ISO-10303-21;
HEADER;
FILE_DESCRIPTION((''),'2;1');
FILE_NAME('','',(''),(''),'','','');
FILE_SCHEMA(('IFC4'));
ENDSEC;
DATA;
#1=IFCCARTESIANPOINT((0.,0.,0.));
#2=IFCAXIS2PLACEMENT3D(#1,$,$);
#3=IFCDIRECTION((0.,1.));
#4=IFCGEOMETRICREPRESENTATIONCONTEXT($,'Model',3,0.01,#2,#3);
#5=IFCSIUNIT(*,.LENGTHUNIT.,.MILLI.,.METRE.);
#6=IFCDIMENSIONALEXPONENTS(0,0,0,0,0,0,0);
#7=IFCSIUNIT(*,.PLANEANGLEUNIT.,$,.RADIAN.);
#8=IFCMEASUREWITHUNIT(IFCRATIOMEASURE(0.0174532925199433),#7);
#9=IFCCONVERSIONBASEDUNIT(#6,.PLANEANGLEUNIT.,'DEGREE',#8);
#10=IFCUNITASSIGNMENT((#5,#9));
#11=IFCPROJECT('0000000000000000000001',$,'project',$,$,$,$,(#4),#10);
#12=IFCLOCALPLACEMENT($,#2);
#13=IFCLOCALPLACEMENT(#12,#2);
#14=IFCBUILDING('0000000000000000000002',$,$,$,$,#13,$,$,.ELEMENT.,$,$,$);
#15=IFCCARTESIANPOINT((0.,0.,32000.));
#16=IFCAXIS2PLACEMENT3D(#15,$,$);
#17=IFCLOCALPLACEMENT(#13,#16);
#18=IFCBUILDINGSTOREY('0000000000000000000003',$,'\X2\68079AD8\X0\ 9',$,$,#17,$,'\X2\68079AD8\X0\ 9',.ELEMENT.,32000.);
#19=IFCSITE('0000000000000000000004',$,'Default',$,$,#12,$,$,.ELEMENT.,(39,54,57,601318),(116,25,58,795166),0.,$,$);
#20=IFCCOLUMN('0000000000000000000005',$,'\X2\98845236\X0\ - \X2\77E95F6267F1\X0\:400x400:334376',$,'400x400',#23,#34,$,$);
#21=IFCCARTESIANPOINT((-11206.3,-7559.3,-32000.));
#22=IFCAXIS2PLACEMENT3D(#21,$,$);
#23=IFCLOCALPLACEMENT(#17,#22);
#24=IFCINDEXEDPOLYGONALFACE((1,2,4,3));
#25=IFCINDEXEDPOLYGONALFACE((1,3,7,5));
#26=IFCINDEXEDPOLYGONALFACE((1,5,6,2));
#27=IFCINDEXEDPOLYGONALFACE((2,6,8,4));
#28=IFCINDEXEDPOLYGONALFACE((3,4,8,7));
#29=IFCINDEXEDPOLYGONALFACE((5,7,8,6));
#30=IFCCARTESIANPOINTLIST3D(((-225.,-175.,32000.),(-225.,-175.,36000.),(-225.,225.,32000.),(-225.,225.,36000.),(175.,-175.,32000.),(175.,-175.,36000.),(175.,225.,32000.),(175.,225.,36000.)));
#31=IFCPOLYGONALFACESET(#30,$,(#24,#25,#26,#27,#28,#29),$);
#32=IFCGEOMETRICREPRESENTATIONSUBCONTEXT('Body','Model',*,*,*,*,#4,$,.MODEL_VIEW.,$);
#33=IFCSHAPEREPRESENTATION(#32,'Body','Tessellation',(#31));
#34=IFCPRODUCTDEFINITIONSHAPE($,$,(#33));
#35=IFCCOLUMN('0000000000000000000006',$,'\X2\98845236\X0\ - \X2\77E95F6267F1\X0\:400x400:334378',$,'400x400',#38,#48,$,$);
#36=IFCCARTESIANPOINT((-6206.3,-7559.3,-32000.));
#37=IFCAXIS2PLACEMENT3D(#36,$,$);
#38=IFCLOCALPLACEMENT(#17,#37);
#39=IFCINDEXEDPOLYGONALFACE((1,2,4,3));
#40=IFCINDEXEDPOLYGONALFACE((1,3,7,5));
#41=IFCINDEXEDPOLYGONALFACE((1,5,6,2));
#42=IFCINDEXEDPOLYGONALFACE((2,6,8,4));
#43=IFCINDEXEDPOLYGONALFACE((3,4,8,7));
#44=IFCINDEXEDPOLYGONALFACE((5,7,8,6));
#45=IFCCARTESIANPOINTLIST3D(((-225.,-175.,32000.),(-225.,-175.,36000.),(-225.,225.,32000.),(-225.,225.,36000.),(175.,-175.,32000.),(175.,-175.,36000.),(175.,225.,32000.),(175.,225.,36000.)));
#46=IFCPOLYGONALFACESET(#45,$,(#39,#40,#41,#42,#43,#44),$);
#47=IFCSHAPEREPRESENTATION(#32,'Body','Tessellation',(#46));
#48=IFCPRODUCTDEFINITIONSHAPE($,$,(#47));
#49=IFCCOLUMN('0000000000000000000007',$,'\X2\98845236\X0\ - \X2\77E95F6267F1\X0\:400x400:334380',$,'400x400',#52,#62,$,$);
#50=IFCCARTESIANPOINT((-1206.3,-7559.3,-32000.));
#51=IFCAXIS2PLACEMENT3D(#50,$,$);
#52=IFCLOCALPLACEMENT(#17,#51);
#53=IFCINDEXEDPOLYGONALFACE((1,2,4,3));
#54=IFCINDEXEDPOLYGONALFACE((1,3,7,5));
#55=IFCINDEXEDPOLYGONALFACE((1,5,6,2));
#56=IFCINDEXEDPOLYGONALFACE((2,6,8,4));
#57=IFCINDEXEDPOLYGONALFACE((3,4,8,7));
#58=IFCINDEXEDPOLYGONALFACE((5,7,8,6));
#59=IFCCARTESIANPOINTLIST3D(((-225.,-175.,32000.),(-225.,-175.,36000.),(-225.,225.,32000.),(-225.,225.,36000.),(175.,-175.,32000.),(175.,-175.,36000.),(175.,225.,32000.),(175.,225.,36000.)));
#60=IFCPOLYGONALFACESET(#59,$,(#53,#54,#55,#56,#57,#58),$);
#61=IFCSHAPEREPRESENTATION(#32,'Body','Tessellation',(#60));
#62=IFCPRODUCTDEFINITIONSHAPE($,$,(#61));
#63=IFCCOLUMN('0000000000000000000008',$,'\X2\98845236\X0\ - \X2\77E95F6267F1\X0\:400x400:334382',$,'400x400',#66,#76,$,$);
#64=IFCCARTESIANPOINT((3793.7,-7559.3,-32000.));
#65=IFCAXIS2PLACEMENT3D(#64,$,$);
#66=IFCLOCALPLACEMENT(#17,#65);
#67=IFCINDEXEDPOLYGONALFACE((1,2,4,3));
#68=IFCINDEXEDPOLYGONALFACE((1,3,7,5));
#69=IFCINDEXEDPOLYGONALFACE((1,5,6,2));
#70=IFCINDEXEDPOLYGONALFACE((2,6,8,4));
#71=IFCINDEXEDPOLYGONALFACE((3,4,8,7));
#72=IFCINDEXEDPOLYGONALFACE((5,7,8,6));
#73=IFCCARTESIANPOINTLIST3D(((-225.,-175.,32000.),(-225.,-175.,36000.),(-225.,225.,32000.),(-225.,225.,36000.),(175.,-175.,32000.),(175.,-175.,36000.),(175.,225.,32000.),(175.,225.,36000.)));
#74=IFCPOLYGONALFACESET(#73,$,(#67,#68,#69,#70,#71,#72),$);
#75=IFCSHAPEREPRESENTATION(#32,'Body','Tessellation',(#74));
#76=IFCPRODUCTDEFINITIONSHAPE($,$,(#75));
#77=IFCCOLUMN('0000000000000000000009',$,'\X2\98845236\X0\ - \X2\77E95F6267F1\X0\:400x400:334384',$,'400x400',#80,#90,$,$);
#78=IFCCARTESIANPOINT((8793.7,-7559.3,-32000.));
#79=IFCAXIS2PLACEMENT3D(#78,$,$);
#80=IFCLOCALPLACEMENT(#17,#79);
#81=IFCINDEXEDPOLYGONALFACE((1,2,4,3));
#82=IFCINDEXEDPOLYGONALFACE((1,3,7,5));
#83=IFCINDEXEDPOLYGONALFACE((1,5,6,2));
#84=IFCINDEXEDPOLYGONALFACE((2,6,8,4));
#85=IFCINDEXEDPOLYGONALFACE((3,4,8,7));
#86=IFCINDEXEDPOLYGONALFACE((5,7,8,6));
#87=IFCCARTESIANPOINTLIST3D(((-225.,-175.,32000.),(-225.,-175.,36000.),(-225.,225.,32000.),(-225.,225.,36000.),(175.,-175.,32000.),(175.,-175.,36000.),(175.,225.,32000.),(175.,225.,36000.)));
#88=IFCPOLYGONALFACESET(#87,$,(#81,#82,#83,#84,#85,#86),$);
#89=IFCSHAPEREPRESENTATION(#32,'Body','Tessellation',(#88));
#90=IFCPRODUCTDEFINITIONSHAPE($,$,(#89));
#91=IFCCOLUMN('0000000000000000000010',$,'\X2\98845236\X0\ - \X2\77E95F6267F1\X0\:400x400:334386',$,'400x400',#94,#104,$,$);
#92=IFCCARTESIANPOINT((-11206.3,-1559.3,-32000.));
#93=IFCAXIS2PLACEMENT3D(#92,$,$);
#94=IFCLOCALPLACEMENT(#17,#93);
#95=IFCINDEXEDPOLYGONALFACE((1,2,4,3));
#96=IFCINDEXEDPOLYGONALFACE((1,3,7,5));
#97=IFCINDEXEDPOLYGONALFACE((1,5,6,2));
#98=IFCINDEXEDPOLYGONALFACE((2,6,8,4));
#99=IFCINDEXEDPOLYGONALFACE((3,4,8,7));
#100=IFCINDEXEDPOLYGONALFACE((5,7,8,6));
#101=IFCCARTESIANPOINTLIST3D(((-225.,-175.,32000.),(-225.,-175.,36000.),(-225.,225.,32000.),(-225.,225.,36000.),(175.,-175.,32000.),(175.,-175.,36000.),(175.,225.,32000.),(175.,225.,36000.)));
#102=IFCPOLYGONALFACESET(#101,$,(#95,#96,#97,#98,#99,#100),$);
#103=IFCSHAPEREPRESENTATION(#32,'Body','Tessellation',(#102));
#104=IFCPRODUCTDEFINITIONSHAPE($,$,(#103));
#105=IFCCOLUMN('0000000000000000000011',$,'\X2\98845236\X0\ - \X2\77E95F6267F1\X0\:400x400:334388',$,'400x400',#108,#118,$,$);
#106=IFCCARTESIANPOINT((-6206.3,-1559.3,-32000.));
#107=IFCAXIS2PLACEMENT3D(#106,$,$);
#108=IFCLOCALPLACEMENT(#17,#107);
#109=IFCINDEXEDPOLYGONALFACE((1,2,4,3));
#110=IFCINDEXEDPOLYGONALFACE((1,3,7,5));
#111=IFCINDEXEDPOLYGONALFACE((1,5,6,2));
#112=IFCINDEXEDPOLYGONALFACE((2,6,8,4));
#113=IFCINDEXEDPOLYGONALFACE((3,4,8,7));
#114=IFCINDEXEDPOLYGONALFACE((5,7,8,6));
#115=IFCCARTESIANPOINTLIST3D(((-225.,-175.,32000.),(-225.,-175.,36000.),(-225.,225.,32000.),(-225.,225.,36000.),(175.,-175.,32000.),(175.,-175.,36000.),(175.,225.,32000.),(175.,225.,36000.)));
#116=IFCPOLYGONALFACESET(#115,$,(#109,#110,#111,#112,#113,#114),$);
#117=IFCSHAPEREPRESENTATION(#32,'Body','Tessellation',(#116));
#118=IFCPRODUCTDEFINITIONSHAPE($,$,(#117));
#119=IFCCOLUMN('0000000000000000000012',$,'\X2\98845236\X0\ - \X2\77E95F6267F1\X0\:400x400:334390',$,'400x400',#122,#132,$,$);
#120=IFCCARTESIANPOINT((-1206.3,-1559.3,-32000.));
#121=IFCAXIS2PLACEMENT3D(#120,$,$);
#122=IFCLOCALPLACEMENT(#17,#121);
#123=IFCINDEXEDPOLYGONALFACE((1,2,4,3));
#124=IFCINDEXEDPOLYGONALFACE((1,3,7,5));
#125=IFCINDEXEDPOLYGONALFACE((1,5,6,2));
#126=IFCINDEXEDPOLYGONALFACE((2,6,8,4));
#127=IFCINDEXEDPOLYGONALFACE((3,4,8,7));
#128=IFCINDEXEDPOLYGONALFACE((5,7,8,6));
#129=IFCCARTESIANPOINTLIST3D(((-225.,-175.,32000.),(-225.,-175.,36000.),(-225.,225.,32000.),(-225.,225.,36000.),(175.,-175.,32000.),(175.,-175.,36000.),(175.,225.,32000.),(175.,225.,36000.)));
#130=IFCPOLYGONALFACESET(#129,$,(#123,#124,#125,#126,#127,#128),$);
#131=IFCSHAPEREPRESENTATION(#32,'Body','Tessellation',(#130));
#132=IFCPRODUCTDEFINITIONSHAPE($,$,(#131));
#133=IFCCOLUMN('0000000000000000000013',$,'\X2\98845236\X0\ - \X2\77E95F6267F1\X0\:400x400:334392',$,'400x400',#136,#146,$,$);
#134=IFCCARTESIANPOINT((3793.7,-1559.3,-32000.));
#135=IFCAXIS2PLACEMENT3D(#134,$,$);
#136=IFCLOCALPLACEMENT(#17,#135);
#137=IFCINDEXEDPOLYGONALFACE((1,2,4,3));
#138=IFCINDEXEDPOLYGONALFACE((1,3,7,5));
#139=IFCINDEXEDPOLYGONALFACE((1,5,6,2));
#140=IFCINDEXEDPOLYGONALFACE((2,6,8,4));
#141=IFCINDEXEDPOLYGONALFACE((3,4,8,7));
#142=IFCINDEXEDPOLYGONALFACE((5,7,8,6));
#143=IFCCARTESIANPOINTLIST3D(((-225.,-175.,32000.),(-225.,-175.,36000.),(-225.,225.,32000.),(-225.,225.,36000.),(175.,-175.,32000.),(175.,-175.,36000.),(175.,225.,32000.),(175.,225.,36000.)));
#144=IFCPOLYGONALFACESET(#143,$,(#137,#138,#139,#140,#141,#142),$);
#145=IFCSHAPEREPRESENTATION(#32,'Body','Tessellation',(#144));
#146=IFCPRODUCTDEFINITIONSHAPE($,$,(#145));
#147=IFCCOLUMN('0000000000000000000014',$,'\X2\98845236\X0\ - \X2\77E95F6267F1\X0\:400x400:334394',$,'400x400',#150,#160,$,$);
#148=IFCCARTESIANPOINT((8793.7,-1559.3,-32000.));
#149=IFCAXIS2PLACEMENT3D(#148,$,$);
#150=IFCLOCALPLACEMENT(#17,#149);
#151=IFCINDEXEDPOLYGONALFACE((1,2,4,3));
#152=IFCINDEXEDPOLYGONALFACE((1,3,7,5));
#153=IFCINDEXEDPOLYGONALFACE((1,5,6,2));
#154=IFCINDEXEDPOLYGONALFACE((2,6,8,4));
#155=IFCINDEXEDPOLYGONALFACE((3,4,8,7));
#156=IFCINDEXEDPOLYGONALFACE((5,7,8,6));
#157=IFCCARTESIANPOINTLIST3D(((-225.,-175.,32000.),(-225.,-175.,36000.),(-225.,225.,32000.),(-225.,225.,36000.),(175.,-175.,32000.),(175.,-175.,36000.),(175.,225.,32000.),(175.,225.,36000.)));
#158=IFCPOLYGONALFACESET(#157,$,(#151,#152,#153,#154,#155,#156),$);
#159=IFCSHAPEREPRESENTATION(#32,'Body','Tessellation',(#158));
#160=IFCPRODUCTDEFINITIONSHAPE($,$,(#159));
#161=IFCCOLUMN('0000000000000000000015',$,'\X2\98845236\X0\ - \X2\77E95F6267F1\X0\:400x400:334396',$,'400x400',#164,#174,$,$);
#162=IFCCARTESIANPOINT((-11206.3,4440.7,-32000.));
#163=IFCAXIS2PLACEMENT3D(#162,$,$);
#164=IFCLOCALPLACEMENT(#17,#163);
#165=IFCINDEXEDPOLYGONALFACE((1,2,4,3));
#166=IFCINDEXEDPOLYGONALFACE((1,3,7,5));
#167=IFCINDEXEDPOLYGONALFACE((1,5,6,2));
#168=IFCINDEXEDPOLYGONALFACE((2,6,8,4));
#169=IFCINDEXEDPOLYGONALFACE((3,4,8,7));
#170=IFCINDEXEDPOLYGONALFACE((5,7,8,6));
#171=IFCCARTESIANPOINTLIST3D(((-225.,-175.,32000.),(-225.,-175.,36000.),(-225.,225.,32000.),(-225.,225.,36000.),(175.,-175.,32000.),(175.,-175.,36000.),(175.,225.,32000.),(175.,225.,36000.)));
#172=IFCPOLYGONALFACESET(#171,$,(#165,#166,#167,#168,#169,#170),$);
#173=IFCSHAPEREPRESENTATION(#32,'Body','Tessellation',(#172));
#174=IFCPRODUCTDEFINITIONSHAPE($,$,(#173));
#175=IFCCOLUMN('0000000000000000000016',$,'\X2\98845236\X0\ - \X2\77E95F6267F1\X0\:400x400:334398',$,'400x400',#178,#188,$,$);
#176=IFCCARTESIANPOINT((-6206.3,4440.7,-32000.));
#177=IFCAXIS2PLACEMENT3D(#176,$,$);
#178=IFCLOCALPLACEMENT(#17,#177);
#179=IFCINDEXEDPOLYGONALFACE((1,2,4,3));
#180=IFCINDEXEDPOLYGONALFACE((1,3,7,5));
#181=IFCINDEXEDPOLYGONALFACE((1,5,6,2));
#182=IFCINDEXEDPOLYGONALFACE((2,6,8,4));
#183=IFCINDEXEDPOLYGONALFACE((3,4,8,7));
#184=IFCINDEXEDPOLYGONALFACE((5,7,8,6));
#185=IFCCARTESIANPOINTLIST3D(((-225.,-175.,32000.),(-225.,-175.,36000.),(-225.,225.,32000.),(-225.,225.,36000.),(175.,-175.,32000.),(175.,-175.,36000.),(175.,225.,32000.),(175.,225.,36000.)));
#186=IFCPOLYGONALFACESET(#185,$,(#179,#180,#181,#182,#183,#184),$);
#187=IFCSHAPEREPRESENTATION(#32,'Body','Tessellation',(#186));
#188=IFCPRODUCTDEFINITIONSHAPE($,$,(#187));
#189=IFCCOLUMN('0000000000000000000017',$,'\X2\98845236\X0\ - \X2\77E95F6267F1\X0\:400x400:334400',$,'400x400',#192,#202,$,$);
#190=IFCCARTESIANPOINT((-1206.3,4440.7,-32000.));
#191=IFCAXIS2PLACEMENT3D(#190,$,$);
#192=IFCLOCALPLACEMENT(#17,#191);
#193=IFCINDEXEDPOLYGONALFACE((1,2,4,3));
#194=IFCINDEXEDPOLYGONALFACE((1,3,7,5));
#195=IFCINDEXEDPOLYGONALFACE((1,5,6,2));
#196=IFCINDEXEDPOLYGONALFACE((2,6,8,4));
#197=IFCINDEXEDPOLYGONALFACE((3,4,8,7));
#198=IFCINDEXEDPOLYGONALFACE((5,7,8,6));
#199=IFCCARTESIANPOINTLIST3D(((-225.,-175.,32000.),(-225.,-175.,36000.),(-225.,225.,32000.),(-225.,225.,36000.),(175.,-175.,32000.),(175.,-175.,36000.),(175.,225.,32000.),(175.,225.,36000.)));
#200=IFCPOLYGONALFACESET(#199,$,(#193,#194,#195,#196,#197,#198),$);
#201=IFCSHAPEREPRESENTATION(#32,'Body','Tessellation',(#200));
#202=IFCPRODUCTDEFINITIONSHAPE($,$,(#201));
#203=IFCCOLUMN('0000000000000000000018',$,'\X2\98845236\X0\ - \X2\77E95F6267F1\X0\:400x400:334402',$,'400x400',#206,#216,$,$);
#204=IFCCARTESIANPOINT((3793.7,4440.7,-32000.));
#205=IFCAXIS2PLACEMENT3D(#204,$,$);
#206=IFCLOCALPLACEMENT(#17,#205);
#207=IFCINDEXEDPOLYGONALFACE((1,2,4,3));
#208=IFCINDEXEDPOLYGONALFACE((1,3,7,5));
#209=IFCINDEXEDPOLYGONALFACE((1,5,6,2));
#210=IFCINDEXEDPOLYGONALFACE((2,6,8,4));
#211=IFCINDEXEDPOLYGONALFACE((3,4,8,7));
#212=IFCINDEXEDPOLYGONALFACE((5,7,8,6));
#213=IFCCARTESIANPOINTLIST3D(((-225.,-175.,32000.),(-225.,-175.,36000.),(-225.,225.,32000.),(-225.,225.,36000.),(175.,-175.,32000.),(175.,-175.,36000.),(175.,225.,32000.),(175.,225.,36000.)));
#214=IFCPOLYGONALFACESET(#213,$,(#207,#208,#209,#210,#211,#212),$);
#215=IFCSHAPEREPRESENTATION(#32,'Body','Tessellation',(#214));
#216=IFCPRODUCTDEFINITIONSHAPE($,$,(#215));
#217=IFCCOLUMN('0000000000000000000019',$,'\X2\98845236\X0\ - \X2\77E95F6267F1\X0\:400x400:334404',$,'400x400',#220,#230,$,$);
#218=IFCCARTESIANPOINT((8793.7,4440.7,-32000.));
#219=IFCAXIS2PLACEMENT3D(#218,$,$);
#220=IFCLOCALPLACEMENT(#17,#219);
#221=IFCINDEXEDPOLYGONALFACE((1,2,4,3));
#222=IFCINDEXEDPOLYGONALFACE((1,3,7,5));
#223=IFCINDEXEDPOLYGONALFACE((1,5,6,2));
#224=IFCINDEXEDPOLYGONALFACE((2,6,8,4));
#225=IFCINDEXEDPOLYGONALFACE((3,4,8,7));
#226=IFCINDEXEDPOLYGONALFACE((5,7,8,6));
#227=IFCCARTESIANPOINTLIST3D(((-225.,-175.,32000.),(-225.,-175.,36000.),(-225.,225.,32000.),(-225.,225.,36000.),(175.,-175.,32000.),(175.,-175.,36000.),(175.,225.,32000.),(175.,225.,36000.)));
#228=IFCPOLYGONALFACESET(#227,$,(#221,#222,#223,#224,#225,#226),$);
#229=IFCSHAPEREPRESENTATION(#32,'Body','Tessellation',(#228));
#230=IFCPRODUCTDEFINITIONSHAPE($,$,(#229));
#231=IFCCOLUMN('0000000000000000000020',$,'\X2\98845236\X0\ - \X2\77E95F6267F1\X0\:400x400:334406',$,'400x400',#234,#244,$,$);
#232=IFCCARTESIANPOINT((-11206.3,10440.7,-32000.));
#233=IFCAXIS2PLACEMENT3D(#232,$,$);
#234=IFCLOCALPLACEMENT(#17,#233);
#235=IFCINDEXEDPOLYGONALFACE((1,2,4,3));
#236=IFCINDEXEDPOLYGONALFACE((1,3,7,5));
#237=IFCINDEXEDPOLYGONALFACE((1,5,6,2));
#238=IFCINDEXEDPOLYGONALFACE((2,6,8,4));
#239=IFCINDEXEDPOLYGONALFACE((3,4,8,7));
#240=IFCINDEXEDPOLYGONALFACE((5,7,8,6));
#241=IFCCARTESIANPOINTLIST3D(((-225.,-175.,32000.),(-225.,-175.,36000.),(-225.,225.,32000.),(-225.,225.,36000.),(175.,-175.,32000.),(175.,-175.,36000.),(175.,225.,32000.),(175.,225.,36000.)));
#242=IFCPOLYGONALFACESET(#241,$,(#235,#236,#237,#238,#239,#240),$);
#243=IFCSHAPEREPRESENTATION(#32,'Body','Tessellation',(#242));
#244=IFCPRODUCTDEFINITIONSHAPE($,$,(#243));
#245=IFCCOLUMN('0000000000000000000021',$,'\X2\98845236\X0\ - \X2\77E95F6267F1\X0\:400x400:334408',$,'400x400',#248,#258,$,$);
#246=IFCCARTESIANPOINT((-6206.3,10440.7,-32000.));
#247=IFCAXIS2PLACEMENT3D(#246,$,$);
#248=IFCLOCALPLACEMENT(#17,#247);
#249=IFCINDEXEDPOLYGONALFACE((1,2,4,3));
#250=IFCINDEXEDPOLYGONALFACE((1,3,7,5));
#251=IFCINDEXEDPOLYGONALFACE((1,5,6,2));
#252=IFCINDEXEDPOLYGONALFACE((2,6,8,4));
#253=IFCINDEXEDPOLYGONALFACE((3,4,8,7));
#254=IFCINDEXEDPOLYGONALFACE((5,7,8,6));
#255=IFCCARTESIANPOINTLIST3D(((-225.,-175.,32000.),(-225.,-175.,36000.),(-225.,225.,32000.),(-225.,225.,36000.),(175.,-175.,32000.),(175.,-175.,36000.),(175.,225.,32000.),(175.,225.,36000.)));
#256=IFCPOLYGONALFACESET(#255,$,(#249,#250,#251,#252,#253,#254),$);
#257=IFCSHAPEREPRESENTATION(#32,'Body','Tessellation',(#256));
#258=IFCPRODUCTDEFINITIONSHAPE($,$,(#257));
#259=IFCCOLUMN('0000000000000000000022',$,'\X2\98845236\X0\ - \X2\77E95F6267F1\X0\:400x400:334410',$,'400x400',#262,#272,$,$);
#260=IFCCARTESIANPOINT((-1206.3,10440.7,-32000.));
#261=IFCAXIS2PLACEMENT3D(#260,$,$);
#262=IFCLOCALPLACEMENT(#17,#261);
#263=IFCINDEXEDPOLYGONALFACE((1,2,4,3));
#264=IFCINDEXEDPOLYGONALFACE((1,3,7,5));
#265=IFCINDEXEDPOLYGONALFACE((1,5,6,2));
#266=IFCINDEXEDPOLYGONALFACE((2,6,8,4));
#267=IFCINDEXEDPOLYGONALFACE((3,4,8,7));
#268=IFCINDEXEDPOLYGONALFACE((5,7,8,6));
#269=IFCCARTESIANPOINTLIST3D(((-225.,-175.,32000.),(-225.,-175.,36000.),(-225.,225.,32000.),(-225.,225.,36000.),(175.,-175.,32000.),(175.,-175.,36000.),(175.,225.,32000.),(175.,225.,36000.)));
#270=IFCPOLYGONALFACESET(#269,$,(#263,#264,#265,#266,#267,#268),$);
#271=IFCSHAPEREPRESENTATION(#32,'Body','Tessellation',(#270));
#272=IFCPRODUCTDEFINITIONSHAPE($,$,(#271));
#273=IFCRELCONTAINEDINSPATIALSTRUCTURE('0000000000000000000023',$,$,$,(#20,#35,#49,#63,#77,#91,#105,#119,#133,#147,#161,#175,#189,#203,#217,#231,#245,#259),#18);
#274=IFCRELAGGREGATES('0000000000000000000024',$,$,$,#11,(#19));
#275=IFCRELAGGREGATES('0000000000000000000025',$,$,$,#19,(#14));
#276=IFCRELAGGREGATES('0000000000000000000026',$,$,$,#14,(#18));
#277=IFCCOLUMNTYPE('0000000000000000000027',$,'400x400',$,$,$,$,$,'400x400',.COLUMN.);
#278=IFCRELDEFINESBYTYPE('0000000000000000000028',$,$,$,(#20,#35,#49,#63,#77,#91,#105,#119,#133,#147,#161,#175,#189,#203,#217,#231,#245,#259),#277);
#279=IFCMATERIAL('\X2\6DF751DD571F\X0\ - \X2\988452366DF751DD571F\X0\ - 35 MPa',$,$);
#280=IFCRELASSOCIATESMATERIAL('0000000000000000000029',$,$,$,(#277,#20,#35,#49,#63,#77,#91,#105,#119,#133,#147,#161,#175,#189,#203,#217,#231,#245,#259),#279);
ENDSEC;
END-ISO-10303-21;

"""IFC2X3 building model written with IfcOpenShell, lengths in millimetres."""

from ifc_helpers import new_model, entity, si_unit, converted_unit, direction, frame, frame_2d, origin, place, context, subcontext, project, spatial, rectangle, extrude, source, transform, mapped, material, type_object, type_shapes, element, save


model = new_model("IFC2X3")

# Units and contexts
model_context = context("Model", 3, precision=0.01, world=origin(), true_north=direction((0.0, 1.0)))
body_context = subcontext(model_context, "Body", "Model", "MODEL_VIEW")
ifc_project = project(units=[si_unit("LENGTHUNIT", "METRE", prefix="MILLI"), converted_unit("PLANEANGLEUNIT", "DEGREE", entity("IfcRatioMeasure", 0.0174532925199433), si_unit("PLANEANGLEUNIT", "RADIAN"), dimensions=[0, 0, 0, 0, 0, 0, 0])], contexts=[model_context])

# Site, building, storey
site_placement = place(None, origin())
site = spatial("IfcSite", under=ifc_project, at=site_placement, Name="Default", CompositionType="ELEMENT", RefLatitude=(39, 54, 57, 601318), RefLongitude=(116, 25, 58, 795166), RefElevation=0.0)
building_placement = place(site_placement, origin())
building = spatial("IfcBuilding", under=site, at=building_placement, CompositionType="ELEMENT")
storey_placement = place(building_placement, frame((0.0, 0.0, 32000.0)))
storey = spatial("IfcBuildingStorey", under=building, at=storey_placement, Name="标高 9", LongName="标高 9", CompositionType="ELEMENT", Elevation=32000.0)

# Columns
ifc_material = material(Name="混凝土 - 预制混凝土 - 35 MPa")
column_type = type_object("IfcColumnType", Name="400x400", ElementType="400x400", PredefinedType="COLUMN", material=ifc_material)
shared_shape = source(origin(), body_context, "Body", "SweptSolid", [
    extrude(rectangle(XDim=400.0, YDim=400.0, at=frame_2d((0.0, 0.0), x_axis=(1.0, 0.0))), frame((-25.0, 25.0, 32000.0)), (0.0, 0.0, 1.0), 4000.0),
])
type_shapes(column_type, [shared_shape])
for number, where, name in (
    (1, (-11206.3, -7559.3, -32000.0), "预制 - 矩形柱:400x400:334376"),
    (2, (-6206.3, -7559.3, -32000.0), "预制 - 矩形柱:400x400:334378"),
    (3, (-1206.3, -7559.3, -32000.0), "预制 - 矩形柱:400x400:334380"),
    (4, (3793.7, -7559.3, -32000.0), "预制 - 矩形柱:400x400:334382"),
    (5, (8793.7, -7559.3, -32000.0), "预制 - 矩形柱:400x400:334384"),
    (6, (-11206.3, -1559.3, -32000.0), "预制 - 矩形柱:400x400:334386"),
    (7, (-6206.3, -1559.3, -32000.0), "预制 - 矩形柱:400x400:334388"),
    (8, (-1206.3, -1559.3, -32000.0), "预制 - 矩形柱:400x400:334390"),
    (9, (3793.7, -1559.3, -32000.0), "预制 - 矩形柱:400x400:334392"),
    (10, (8793.7, -1559.3, -32000.0), "预制 - 矩形柱:400x400:334394"),
    (11, (-11206.3, 4440.7, -32000.0), "预制 - 矩形柱:400x400:334396"),
    (12, (-6206.3, 4440.7, -32000.0), "预制 - 矩形柱:400x400:334398"),
    (13, (-1206.3, 4440.7, -32000.0), "预制 - 矩形柱:400x400:334400"),
    (14, (3793.7, 4440.7, -32000.0), "预制 - 矩形柱:400x400:334402"),
    (15, (8793.7, 4440.7, -32000.0), "预制 - 矩形柱:400x400:334404"),
    (16, (-11206.3, 10440.7, -32000.0), "预制 - 矩形柱:400x400:334406"),
    (17, (-6206.3, 10440.7, -32000.0), "预制 - 矩形柱:400x400:334408"),
    (18, (-1206.3, 10440.7, -32000.0), "预制 - 矩形柱:400x400:334410"),
):
    element("IfcColumn", number, at=place(storey_placement, frame(where)), inside=storey, type_object=column_type, material=ifc_material, Name=name, ObjectType="400x400", context=body_context, shape_type="MappedRepresentation", body=[
        mapped(shared_shape, transform((0.0, 0.0, 0.0), scale=1.0)),
    ])

save(model, "model.ifc")
